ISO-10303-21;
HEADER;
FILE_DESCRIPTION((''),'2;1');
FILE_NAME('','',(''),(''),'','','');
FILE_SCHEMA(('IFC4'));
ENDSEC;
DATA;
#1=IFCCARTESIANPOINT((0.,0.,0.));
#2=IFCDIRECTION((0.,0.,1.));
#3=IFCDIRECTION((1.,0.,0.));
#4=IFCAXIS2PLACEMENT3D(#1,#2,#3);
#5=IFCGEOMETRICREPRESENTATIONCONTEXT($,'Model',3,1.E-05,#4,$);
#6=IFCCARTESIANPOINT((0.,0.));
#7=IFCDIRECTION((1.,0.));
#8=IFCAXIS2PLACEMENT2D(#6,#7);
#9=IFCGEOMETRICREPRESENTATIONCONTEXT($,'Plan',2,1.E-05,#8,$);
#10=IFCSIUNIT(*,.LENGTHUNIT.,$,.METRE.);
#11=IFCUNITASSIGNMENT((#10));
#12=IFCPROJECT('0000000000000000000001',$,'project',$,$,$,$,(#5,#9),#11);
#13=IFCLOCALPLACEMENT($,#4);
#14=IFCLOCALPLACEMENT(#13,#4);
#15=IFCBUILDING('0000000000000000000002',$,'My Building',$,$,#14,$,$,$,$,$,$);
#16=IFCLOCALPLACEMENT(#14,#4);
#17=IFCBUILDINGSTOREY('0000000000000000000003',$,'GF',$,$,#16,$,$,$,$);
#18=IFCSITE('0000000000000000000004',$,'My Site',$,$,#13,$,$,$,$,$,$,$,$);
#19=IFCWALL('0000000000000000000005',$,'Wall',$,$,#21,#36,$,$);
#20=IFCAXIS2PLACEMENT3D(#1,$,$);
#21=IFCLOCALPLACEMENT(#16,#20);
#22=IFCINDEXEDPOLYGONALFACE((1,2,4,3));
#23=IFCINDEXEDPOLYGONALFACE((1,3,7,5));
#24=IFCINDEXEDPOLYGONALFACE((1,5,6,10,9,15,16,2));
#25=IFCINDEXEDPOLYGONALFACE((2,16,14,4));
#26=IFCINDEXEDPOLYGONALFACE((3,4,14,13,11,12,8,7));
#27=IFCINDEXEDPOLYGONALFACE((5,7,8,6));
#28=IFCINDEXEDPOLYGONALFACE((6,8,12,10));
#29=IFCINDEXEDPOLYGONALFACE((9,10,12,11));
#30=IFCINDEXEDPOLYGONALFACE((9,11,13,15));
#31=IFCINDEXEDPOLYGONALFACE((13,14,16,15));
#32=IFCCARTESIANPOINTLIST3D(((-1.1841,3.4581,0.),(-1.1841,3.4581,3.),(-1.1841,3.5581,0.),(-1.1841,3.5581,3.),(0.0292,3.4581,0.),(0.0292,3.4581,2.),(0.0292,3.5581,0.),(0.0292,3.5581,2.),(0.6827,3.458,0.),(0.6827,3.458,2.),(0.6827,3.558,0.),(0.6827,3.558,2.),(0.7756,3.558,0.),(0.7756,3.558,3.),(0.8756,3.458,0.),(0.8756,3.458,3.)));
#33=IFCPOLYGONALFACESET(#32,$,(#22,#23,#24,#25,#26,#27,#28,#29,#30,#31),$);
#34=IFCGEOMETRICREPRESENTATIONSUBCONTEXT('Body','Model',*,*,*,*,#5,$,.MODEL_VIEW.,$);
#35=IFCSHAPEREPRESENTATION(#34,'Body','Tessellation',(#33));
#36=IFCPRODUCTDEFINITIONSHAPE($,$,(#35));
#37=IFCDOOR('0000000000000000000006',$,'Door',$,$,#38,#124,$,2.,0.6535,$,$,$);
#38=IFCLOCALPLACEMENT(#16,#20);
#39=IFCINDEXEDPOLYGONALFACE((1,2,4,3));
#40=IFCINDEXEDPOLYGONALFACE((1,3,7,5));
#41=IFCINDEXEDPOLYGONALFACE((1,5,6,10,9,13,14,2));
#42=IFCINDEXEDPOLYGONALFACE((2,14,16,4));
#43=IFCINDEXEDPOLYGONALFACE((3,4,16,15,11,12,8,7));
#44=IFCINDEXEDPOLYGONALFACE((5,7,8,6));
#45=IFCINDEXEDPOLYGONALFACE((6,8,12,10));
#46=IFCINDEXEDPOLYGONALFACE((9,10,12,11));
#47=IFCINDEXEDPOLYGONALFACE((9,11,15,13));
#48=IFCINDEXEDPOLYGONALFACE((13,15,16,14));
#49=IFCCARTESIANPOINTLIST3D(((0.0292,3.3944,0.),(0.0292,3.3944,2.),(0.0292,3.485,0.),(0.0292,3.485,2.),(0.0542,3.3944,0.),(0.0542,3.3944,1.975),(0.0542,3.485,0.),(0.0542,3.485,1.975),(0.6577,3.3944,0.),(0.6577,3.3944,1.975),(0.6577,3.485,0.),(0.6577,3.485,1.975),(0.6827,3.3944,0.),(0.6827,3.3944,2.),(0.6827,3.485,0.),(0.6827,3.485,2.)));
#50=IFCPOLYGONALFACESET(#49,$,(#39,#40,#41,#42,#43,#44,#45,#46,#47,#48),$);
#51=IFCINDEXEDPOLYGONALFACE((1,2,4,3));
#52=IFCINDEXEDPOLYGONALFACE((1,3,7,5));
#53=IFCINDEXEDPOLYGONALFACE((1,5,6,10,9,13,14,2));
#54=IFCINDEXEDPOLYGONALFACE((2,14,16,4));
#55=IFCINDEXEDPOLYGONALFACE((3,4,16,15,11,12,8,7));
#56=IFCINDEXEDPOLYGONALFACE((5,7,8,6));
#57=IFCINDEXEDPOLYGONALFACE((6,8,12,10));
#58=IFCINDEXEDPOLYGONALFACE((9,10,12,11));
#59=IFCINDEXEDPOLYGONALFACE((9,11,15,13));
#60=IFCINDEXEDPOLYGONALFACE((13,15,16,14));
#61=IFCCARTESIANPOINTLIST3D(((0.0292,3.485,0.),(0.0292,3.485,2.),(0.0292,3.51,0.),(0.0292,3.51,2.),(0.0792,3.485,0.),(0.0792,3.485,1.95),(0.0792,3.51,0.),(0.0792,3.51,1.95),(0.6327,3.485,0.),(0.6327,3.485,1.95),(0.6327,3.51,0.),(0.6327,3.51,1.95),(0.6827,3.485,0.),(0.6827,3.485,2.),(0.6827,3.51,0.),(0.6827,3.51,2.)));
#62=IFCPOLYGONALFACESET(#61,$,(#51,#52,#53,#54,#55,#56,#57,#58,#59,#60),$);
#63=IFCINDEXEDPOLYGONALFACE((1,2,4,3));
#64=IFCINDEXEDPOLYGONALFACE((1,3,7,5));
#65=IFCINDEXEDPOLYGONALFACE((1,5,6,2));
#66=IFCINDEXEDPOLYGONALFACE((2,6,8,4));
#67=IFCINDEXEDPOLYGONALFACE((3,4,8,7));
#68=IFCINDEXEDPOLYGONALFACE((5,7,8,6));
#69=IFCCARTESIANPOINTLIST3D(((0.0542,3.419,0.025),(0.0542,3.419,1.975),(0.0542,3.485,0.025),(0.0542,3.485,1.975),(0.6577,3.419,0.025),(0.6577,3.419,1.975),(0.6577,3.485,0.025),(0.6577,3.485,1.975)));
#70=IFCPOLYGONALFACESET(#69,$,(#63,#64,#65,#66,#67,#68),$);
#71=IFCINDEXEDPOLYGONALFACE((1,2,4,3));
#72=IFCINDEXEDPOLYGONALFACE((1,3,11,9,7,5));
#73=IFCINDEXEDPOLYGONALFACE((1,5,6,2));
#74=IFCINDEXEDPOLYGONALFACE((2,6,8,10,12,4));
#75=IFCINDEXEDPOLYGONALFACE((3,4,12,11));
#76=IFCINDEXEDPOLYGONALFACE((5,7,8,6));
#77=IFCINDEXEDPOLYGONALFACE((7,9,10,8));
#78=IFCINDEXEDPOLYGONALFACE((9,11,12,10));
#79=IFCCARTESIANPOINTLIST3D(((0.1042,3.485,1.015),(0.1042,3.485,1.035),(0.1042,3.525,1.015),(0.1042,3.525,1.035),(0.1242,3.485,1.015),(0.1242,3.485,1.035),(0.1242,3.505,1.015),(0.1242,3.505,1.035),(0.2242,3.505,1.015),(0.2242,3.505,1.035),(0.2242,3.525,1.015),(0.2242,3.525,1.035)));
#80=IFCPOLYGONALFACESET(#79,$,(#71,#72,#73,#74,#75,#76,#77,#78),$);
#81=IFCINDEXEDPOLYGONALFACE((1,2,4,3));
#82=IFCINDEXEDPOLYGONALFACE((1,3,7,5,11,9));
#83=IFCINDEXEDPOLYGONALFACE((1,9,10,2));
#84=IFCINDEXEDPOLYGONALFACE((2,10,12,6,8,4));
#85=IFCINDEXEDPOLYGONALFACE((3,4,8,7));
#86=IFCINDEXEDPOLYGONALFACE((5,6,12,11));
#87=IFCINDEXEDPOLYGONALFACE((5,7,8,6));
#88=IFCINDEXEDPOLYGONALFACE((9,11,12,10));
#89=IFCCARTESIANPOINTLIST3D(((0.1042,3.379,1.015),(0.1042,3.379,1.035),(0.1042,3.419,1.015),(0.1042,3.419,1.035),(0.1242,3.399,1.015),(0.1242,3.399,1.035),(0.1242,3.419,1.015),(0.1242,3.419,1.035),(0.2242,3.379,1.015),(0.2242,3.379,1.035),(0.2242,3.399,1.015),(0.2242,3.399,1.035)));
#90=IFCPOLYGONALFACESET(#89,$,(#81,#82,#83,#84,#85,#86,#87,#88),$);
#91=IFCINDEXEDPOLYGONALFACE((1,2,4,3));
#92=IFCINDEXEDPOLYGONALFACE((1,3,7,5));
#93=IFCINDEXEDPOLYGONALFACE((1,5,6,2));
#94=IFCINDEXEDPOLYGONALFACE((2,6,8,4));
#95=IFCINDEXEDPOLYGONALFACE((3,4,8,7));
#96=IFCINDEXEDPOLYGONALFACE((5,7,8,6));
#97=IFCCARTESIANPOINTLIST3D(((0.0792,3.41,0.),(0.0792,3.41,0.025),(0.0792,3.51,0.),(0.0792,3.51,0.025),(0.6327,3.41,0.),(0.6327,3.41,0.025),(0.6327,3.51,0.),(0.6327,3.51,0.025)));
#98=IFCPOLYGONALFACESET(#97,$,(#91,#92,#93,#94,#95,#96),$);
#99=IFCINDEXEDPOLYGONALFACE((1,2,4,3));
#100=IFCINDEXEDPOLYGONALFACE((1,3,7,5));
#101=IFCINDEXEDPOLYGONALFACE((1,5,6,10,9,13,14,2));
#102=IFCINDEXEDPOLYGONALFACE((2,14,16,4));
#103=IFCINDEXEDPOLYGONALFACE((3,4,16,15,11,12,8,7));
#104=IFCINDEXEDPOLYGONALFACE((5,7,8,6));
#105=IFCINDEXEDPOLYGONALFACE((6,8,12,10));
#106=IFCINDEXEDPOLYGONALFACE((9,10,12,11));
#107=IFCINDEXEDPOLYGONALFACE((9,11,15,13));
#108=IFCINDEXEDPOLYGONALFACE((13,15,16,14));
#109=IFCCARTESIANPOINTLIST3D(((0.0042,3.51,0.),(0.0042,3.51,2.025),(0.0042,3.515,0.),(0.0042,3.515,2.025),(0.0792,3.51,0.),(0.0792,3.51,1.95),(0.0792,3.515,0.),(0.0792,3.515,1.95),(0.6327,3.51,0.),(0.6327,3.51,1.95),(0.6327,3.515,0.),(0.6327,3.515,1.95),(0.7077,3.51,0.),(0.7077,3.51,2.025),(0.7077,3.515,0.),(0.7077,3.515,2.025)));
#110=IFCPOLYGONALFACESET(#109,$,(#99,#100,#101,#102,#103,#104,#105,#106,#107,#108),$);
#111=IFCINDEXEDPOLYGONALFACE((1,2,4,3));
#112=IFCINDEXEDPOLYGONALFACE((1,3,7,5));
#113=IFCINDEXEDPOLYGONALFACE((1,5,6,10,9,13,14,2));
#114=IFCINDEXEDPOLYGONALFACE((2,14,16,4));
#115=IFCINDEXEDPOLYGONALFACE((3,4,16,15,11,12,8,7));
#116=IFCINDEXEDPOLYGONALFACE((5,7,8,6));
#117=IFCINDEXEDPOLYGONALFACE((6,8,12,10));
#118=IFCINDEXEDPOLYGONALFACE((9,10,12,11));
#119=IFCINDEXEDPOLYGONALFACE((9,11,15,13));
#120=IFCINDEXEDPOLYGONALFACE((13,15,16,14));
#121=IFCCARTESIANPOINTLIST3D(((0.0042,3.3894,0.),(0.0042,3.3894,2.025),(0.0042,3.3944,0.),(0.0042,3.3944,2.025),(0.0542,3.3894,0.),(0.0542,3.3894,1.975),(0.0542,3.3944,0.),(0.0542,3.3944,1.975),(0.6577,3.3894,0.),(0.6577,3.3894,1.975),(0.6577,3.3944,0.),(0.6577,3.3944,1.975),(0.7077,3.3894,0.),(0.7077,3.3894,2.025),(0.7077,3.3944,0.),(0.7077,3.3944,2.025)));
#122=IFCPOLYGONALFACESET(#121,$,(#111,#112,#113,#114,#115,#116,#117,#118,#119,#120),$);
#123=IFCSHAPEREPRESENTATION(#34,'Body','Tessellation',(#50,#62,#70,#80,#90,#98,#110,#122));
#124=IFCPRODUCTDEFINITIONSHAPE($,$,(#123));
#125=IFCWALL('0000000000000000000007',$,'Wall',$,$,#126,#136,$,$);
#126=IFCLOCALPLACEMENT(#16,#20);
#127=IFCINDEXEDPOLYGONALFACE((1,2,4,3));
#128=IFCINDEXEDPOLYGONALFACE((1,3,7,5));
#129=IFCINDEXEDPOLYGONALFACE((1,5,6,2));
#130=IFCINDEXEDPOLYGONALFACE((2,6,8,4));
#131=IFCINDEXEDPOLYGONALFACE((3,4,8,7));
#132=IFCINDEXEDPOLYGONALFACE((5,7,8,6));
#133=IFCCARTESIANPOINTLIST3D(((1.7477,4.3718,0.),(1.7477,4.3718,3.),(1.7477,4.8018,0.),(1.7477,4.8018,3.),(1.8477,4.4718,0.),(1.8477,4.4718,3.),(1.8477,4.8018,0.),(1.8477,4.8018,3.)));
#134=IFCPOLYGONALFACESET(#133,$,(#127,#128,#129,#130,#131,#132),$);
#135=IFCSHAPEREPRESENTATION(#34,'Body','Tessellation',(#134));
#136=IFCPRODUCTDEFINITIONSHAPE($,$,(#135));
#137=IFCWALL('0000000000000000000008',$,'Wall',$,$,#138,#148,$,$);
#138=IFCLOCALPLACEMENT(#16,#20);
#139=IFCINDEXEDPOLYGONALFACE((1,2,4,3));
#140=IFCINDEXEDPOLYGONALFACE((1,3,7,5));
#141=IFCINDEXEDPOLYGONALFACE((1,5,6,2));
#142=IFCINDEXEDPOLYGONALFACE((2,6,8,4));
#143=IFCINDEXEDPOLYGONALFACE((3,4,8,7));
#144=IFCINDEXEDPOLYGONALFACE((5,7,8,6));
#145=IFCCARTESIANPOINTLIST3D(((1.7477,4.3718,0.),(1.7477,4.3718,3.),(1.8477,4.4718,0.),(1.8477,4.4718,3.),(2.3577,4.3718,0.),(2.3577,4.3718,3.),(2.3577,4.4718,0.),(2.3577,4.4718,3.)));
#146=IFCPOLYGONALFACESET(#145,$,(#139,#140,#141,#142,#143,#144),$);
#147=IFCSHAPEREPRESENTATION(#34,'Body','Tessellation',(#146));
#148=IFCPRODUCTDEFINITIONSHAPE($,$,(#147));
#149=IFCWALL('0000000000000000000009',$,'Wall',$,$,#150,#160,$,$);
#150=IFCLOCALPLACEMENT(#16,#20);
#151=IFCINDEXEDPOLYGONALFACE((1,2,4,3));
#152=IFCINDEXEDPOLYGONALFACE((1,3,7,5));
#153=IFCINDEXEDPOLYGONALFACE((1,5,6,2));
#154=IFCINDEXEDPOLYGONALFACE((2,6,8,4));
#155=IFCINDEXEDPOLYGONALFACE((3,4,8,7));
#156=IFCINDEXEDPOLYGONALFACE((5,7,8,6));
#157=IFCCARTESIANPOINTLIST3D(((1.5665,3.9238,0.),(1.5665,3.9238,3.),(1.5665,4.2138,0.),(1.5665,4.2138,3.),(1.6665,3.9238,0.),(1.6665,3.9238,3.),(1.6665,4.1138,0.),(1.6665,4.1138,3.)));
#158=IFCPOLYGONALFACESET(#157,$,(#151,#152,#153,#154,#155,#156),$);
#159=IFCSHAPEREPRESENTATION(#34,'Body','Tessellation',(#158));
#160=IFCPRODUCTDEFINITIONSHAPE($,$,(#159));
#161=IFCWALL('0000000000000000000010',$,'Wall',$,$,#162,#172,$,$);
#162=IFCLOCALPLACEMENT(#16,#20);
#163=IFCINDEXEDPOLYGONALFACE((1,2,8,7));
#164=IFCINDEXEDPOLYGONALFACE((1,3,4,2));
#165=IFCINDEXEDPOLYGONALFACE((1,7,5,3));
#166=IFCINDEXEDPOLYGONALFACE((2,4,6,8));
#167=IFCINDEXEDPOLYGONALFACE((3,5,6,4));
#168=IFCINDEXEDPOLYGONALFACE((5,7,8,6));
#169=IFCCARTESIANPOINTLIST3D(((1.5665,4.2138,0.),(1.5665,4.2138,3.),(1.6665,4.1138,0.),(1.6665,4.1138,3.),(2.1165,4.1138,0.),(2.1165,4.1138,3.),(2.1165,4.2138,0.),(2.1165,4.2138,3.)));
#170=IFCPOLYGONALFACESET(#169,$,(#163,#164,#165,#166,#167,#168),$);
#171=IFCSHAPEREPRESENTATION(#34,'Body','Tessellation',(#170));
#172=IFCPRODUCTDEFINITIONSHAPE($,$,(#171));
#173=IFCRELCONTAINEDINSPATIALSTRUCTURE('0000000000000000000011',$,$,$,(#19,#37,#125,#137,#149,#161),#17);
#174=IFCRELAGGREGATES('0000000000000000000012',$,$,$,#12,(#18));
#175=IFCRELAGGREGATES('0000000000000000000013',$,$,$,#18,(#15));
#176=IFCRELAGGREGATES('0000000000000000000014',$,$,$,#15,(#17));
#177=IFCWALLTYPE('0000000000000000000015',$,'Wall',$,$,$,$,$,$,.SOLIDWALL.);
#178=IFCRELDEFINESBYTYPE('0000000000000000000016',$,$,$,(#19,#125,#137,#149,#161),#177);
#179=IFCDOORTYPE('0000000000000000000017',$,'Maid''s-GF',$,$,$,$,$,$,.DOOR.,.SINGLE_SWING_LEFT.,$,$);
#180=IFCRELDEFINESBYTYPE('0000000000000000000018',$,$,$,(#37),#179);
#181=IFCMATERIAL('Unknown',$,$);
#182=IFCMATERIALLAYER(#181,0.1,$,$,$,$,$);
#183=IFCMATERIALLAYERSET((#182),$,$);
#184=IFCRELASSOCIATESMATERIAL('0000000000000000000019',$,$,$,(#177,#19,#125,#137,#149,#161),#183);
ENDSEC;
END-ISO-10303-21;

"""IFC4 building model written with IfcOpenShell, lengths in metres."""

from ifc_helpers import new_model, entity, si_unit, frame, origin_with_axes, origin_2d_with_axis, place, context, subcontext, project, spatial, line, indexed_curve, outline, extrude, shape, source, transform, mapped, material, layer, layer_set, layer_usage, type_object, type_shapes, element, fill, save


model = new_model("IFC4")

# Units and contexts
model_context = context("Model", 3, precision=1e-05, world=origin_with_axes())
plan_context = context("Plan", 2, precision=1e-05, world=origin_2d_with_axis())
body_context_1 = subcontext(model_context, "Body", "Model", "MODEL_VIEW")
body_context_2 = subcontext(plan_context, "Body", "Plan", "PLAN_VIEW")
ifc_project = project(units=[si_unit("LENGTHUNIT", "METRE")], contexts=[model_context, plan_context])

# Site, building, storey
site_placement = place(None, origin_with_axes())
site = spatial("IfcSite", under=ifc_project, at=site_placement, Name="My Site")
building_placement = place(site_placement, origin_with_axes())
building = spatial("IfcBuilding", under=site, at=building_placement, Name="My Building")
storey_placement = place(building_placement, origin_with_axes())
storey = spatial("IfcBuildingStorey", under=building, at=storey_placement, Name="GF")

# Shared definitions
ifc_material = material(Name="Unknown")

# Shared definitions
ifc_layer_1 = layer(ifc_material, 0.1)
ifc_layer_set_1 = layer_set([ifc_layer_1])
wall_type = type_object("IfcWallType", Name="Wall", PredefinedType="SOLIDWALL", material=ifc_layer_set_1)

# Wall, opening, door
ifc_layer_usage_1 = layer_usage(ifc_layer_set_1, "AXIS2", "POSITIVE", 0.0)
wall_1_placement = place(storey_placement, frame((0.7756, 3.558, 0.0), z_axis=(0.0, 0.0, 1.0), x_axis=(-1.0, 0.0, 0.0)))
wall_1 = element("IfcWall", 1, at=wall_1_placement, inside=storey, type_object=wall_type, material=ifc_layer_usage_1, Name="Wall", context=body_context_1, shape_type="SweptSolid", body=[
    extrude(outline(indexed_curve([(0.0, 0.0), (-0.1, 0.1), (1.9596, 0.1), (1.9596, 0.0)], segments=[line(1, 2, 3, 4, 1)])), origin_with_axes(), (0.0, 0.0, 1.0), 3.0),
])
shared_shape_1 = source(origin_with_axes(), body_context_1, "Body", "SweptSolid", [
    extrude(outline(indexed_curve([(0.0, 0.0), (0.6535, 0.0), (0.6535, 2.0), (0.0, 2.0)], segments=[line(1, 2, 3, 4, 1)])), frame((0.0, -0.6, 0.0), z_axis=(0.0, -1.0, 0.0), x_axis=(1.0, 0.0, 0.0)), (0.0, 0.0, -1.0), 1.2),
])
opening_1_placement = place(wall_1_placement, frame((0.0929, 0.048, 0.0), z_axis=(0.0, 0.0, 1.0), x_axis=(1.0, -0.000002, 0.0)))
opening_1 = element("IfcOpeningElement", 2, at=opening_1_placement, cuts=wall_1, PredefinedType="OPENING", context=body_context_1, shape_type="MappedRepresentation", body=[
    mapped(shared_shape_1, transform((0.0, 0.0, 0.0), x_axis=(1.0, 0.0, 0.0), y_axis=(0.0, 1.0, 0.0), z_axis=(0.0, 0.0, 1.0), scale=1.0)),
])
door_type_1 = type_object("IfcDoorType", Name="Maid's-GF", OperationType="SINGLE_SWING_LEFT", PredefinedType="DOOR")
shared_shape_2 = source(origin_with_axes(), body_context_1, "Body", "SweptSolid", [
    extrude(outline(indexed_curve([(0.0, 0.0), (0.0, 2.0), (0.6535, 2.0), (0.6535, 0.0), (0.6285, 0.0), (0.6285, 1.975), (0.025, 1.975), (0.025, 0.0)], segments=[line(1, 2, 3, 4, 5, 6, 7, 8, 1)])), frame((0.0, 0.025, 0.0), z_axis=(0.0, -1.0, 0.0), x_axis=(1.0, 0.0, 0.0)), (0.0, 0.0, -1.0), 0.0906),
    extrude(outline(indexed_curve([(0.0, 0.0), (0.0, 2.0), (0.6535, 2.0), (0.6535, 0.0), (0.6035, 0.0), (0.6035, 1.95), (0.05, 1.95), (0.05, 0.0)], segments=[line(1, 2, 3, 4, 5, 6, 7, 8, 1)])), frame((0.0, 0.0, 0.0), z_axis=(0.0, -1.0, 0.0), x_axis=(1.0, 0.0, 0.0)), (0.0, 0.0, -1.0), 0.025),
    extrude(outline(indexed_curve([(0.0, 0.0), (0.6035, 0.0), (0.6035, 0.0661), (0.0, 0.0661)], segments=[line(1, 2, 3, 4, 1)])), frame((0.025, 0.025, 0.025), z_axis=(0.0, 0.0, 1.0), x_axis=(1.0, 0.0, 0.0)), (0.0, 0.0, 1.0), 1.95),
    extrude(outline(indexed_curve([(0.0, 0.0), (0.0, -0.04), (-0.12, -0.04), (-0.12, -0.02), (-0.02, -0.02), (-0.02, 0.0)], segments=[line(1, 2, 3, 4, 5, 6, 1)])), frame((0.5785, 0.025, 1.015), z_axis=(0.0, 0.0, 1.0), x_axis=(1.0, 0.0, 0.0)), (0.0, 0.0, 1.0), 0.02),
    extrude(outline(indexed_curve([(0.0, 0.0), (0.0, 0.04), (-0.12, 0.04), (-0.12, 0.02), (-0.02, 0.02), (-0.02, 0.0)], segments=[line(1, 2, 3, 4, 5, 6, 1)])), frame((0.5785, 0.0911, 1.015), z_axis=(0.0, 0.0, 1.0), x_axis=(1.0, 0.0, 0.0)), (0.0, 0.0, 1.0), 0.02),
    extrude(outline(indexed_curve([(0.0, 0.0), (0.5535, 0.0), (0.5535, 0.1), (0.0, 0.1)], segments=[line(1, 2, 3, 4, 1)])), frame((0.05, 0.0, 0.0), z_axis=(0.0, 0.0, 1.0), x_axis=(1.0, 0.0, 0.0)), (0.0, 0.0, 1.0), 0.025),
    extrude(outline(indexed_curve([(0.0, 0.0), (0.0, 2.025), (0.7035, 2.025), (0.7035, 0.0), (0.6285, 0.0), (0.6285, 1.95), (0.075, 1.95), (0.075, 0.0)], segments=[line(1, 2, 3, 4, 5, 6, 7, 8, 1)])), frame((-0.025, -0.005, 0.0), z_axis=(0.0, -1.0, 0.0), x_axis=(1.0, 0.0, 0.0)), (0.0, 0.0, -1.0), 0.005),
    extrude(outline(indexed_curve([(0.0, 0.0), (0.0, 2.025), (0.7035, 2.025), (0.7035, 0.0), (0.6535, 0.0), (0.6535, 1.975), (0.05, 1.975), (0.05, 0.0)], segments=[line(1, 2, 3, 4, 5, 6, 7, 8, 1)])), frame((-0.025, 0.1156, 0.0), z_axis=(0.0, -1.0, 0.0), x_axis=(1.0, 0.0, 0.0)), (0.0, 0.0, -1.0), 0.005),
])
shared_shape_3 = source(origin_with_axes(), body_context_2, "Body", "Curve2D", [
    entity("IfcIndexedPolyCurve", entity("IfcCartesianPointList2D", [[0.0, 0.0], [0.0, 0.1156], [0.025, 0.1156], [0.025, 0.025], [0.05, 0.025], [0.05, 0.0]]), [entity("IfcLineIndex", [1, 2, 3, 4, 5, 6, 1])]),
    entity("IfcIndexedPolyCurve", entity("IfcCartesianPointList2D", [[0.6535, 0.0], [0.6535, 0.1156], [0.6285, 0.1156], [0.6285, 0.025], [0.6035, 0.025], [0.6035, 0.0]]), [entity("IfcLineIndex", [1, 2, 3, 4, 5, 6, 1])]),
    entity("IfcTrimmedCurve", entity("IfcEllipse", entity("IfcAxis2Placement2D", entity("IfcCartesianPoint", [0.0911, 0.1156]), entity("IfcDirection", [1.0, 0.0])), 0.5374, 0.6035), [entity("IfcCartesianPoint", [0.6285, 0.1156])], [entity("IfcCartesianPoint", [0.0911, 0.7191])], True, "CARTESIAN"),
    entity("IfcIndexedPolyCurve", entity("IfcCartesianPointList2D", [[0.025, 0.1156], [0.0911, 0.1156], [0.0911, 0.7191], [0.025, 0.7191]]), [entity("IfcLineIndex", [1, 2, 3, 4, 1])]),
])
type_shapes(door_type_1, [shared_shape_2, shared_shape_3])
door_1_placement = place(opening_1_placement, frame((0.0, 0.0, 0.0), z_axis=(0.0, 0.0, 1.0), x_axis=(1.0, 0.0, 0.0)))
door_1 = element("IfcDoor", 3, at=door_1_placement, inside=storey, type_object=door_type_1, Name="Door", OverallHeight=2.0, OverallWidth=0.6535, shapes=[
    shape(body_context_1, "Body", "MappedRepresentation", [mapped(shared_shape_2, transform((0.0, 0.0, 0.0), x_axis=(1.0, 0.0, 0.0), y_axis=(0.0, 1.0, 0.0), z_axis=(0.0, 0.0, 1.0), scale=1.0))]),
    shape(body_context_2, "Body", "MappedRepresentation", [mapped(shared_shape_3, transform((0.0, 0.0, 0.0), x_axis=(1.0, 0.0, 0.0), y_axis=(0.0, 1.0, 0.0), z_axis=(0.0, 0.0, 1.0), scale=1.0))]),
])
fill(opening_1, door_1)

# Walls
ifc_layer_usage_2 = layer_usage(ifc_layer_set_1, "AXIS2", "POSITIVE", 0.0)
wall_2_placement = place(storey_placement, frame((1.7477, 4.8018, 0.0), z_axis=(0.0, 0.0, 1.0), x_axis=(0.0, -1.0, 0.0)))
element("IfcWall", 4, at=wall_2_placement, inside=storey, type_object=wall_type, material=ifc_layer_usage_2, Name="Wall", context=body_context_1, shape_type="SweptSolid", body=[
    extrude(outline(indexed_curve([(0.0, 0.0), (0.0, 0.1), (0.33, 0.1), (0.43, 0.0)], segments=[line(1, 2, 3, 4, 1)])), origin_with_axes(), (0.0, 0.0, 1.0), 3.0),
])
ifc_layer_usage_3 = layer_usage(ifc_layer_set_1, "AXIS2", "POSITIVE", 0.0)
wall_3_placement = place(storey_placement, frame((1.7477, 4.3718, 0.0), z_axis=(0.0, 0.0, 1.0), x_axis=(1.0, 0.0, 0.0)))
element("IfcWall", 5, at=wall_3_placement, inside=storey, type_object=wall_type, material=ifc_layer_usage_3, Name="Wall", context=body_context_1, shape_type="SweptSolid", body=[
    extrude(outline(indexed_curve([(0.0, 0.0), (0.1, 0.1), (0.61, 0.1), (0.61, 0.0)], segments=[line(1, 2, 3, 4, 1)])), origin_with_axes(), (0.0, 0.0, 1.0), 3.0),
])
ifc_layer_usage_4 = layer_usage(ifc_layer_set_1, "AXIS2", "POSITIVE", 0.0)
wall_4_placement = place(storey_placement, frame((1.5665, 4.1138, 0.0), z_axis=(0.0, 0.0, 1.0), x_axis=(0.0, -1.0, 0.0)))
element("IfcWall", 6, at=wall_4_placement, inside=storey, type_object=wall_type, material=ifc_layer_usage_4, Name="Wall", context=body_context_1, shape_type="SweptSolid", body=[
    extrude(outline(indexed_curve([(-0.1, 0.0), (0.0, 0.1), (0.19, 0.1), (0.19, 0.0)], segments=[line(1, 2, 3, 4, 1)])), origin_with_axes(), (0.0, 0.0, 1.0), 3.0),
])
ifc_layer_usage_5 = layer_usage(ifc_layer_set_1, "AXIS2", "POSITIVE", 0.0)
wall_5_placement = place(storey_placement, frame((1.5665, 4.1138, 0.0), z_axis=(0.0, 0.0, 1.0), x_axis=(1.0, 0.0, 0.0)))
element("IfcWall", 7, at=wall_5_placement, inside=storey, type_object=wall_type, material=ifc_layer_usage_5, Name="Wall", context=body_context_1, shape_type="SweptSolid", body=[
    extrude(outline(indexed_curve([(0.1, 0.0), (0.0, 0.1), (0.55, 0.1), (0.55, 0.0)], segments=[line(1, 2, 3, 4, 1)])), origin_with_axes(), (0.0, 0.0, 1.0), 3.0),
])

save(model, "model.ifc")
